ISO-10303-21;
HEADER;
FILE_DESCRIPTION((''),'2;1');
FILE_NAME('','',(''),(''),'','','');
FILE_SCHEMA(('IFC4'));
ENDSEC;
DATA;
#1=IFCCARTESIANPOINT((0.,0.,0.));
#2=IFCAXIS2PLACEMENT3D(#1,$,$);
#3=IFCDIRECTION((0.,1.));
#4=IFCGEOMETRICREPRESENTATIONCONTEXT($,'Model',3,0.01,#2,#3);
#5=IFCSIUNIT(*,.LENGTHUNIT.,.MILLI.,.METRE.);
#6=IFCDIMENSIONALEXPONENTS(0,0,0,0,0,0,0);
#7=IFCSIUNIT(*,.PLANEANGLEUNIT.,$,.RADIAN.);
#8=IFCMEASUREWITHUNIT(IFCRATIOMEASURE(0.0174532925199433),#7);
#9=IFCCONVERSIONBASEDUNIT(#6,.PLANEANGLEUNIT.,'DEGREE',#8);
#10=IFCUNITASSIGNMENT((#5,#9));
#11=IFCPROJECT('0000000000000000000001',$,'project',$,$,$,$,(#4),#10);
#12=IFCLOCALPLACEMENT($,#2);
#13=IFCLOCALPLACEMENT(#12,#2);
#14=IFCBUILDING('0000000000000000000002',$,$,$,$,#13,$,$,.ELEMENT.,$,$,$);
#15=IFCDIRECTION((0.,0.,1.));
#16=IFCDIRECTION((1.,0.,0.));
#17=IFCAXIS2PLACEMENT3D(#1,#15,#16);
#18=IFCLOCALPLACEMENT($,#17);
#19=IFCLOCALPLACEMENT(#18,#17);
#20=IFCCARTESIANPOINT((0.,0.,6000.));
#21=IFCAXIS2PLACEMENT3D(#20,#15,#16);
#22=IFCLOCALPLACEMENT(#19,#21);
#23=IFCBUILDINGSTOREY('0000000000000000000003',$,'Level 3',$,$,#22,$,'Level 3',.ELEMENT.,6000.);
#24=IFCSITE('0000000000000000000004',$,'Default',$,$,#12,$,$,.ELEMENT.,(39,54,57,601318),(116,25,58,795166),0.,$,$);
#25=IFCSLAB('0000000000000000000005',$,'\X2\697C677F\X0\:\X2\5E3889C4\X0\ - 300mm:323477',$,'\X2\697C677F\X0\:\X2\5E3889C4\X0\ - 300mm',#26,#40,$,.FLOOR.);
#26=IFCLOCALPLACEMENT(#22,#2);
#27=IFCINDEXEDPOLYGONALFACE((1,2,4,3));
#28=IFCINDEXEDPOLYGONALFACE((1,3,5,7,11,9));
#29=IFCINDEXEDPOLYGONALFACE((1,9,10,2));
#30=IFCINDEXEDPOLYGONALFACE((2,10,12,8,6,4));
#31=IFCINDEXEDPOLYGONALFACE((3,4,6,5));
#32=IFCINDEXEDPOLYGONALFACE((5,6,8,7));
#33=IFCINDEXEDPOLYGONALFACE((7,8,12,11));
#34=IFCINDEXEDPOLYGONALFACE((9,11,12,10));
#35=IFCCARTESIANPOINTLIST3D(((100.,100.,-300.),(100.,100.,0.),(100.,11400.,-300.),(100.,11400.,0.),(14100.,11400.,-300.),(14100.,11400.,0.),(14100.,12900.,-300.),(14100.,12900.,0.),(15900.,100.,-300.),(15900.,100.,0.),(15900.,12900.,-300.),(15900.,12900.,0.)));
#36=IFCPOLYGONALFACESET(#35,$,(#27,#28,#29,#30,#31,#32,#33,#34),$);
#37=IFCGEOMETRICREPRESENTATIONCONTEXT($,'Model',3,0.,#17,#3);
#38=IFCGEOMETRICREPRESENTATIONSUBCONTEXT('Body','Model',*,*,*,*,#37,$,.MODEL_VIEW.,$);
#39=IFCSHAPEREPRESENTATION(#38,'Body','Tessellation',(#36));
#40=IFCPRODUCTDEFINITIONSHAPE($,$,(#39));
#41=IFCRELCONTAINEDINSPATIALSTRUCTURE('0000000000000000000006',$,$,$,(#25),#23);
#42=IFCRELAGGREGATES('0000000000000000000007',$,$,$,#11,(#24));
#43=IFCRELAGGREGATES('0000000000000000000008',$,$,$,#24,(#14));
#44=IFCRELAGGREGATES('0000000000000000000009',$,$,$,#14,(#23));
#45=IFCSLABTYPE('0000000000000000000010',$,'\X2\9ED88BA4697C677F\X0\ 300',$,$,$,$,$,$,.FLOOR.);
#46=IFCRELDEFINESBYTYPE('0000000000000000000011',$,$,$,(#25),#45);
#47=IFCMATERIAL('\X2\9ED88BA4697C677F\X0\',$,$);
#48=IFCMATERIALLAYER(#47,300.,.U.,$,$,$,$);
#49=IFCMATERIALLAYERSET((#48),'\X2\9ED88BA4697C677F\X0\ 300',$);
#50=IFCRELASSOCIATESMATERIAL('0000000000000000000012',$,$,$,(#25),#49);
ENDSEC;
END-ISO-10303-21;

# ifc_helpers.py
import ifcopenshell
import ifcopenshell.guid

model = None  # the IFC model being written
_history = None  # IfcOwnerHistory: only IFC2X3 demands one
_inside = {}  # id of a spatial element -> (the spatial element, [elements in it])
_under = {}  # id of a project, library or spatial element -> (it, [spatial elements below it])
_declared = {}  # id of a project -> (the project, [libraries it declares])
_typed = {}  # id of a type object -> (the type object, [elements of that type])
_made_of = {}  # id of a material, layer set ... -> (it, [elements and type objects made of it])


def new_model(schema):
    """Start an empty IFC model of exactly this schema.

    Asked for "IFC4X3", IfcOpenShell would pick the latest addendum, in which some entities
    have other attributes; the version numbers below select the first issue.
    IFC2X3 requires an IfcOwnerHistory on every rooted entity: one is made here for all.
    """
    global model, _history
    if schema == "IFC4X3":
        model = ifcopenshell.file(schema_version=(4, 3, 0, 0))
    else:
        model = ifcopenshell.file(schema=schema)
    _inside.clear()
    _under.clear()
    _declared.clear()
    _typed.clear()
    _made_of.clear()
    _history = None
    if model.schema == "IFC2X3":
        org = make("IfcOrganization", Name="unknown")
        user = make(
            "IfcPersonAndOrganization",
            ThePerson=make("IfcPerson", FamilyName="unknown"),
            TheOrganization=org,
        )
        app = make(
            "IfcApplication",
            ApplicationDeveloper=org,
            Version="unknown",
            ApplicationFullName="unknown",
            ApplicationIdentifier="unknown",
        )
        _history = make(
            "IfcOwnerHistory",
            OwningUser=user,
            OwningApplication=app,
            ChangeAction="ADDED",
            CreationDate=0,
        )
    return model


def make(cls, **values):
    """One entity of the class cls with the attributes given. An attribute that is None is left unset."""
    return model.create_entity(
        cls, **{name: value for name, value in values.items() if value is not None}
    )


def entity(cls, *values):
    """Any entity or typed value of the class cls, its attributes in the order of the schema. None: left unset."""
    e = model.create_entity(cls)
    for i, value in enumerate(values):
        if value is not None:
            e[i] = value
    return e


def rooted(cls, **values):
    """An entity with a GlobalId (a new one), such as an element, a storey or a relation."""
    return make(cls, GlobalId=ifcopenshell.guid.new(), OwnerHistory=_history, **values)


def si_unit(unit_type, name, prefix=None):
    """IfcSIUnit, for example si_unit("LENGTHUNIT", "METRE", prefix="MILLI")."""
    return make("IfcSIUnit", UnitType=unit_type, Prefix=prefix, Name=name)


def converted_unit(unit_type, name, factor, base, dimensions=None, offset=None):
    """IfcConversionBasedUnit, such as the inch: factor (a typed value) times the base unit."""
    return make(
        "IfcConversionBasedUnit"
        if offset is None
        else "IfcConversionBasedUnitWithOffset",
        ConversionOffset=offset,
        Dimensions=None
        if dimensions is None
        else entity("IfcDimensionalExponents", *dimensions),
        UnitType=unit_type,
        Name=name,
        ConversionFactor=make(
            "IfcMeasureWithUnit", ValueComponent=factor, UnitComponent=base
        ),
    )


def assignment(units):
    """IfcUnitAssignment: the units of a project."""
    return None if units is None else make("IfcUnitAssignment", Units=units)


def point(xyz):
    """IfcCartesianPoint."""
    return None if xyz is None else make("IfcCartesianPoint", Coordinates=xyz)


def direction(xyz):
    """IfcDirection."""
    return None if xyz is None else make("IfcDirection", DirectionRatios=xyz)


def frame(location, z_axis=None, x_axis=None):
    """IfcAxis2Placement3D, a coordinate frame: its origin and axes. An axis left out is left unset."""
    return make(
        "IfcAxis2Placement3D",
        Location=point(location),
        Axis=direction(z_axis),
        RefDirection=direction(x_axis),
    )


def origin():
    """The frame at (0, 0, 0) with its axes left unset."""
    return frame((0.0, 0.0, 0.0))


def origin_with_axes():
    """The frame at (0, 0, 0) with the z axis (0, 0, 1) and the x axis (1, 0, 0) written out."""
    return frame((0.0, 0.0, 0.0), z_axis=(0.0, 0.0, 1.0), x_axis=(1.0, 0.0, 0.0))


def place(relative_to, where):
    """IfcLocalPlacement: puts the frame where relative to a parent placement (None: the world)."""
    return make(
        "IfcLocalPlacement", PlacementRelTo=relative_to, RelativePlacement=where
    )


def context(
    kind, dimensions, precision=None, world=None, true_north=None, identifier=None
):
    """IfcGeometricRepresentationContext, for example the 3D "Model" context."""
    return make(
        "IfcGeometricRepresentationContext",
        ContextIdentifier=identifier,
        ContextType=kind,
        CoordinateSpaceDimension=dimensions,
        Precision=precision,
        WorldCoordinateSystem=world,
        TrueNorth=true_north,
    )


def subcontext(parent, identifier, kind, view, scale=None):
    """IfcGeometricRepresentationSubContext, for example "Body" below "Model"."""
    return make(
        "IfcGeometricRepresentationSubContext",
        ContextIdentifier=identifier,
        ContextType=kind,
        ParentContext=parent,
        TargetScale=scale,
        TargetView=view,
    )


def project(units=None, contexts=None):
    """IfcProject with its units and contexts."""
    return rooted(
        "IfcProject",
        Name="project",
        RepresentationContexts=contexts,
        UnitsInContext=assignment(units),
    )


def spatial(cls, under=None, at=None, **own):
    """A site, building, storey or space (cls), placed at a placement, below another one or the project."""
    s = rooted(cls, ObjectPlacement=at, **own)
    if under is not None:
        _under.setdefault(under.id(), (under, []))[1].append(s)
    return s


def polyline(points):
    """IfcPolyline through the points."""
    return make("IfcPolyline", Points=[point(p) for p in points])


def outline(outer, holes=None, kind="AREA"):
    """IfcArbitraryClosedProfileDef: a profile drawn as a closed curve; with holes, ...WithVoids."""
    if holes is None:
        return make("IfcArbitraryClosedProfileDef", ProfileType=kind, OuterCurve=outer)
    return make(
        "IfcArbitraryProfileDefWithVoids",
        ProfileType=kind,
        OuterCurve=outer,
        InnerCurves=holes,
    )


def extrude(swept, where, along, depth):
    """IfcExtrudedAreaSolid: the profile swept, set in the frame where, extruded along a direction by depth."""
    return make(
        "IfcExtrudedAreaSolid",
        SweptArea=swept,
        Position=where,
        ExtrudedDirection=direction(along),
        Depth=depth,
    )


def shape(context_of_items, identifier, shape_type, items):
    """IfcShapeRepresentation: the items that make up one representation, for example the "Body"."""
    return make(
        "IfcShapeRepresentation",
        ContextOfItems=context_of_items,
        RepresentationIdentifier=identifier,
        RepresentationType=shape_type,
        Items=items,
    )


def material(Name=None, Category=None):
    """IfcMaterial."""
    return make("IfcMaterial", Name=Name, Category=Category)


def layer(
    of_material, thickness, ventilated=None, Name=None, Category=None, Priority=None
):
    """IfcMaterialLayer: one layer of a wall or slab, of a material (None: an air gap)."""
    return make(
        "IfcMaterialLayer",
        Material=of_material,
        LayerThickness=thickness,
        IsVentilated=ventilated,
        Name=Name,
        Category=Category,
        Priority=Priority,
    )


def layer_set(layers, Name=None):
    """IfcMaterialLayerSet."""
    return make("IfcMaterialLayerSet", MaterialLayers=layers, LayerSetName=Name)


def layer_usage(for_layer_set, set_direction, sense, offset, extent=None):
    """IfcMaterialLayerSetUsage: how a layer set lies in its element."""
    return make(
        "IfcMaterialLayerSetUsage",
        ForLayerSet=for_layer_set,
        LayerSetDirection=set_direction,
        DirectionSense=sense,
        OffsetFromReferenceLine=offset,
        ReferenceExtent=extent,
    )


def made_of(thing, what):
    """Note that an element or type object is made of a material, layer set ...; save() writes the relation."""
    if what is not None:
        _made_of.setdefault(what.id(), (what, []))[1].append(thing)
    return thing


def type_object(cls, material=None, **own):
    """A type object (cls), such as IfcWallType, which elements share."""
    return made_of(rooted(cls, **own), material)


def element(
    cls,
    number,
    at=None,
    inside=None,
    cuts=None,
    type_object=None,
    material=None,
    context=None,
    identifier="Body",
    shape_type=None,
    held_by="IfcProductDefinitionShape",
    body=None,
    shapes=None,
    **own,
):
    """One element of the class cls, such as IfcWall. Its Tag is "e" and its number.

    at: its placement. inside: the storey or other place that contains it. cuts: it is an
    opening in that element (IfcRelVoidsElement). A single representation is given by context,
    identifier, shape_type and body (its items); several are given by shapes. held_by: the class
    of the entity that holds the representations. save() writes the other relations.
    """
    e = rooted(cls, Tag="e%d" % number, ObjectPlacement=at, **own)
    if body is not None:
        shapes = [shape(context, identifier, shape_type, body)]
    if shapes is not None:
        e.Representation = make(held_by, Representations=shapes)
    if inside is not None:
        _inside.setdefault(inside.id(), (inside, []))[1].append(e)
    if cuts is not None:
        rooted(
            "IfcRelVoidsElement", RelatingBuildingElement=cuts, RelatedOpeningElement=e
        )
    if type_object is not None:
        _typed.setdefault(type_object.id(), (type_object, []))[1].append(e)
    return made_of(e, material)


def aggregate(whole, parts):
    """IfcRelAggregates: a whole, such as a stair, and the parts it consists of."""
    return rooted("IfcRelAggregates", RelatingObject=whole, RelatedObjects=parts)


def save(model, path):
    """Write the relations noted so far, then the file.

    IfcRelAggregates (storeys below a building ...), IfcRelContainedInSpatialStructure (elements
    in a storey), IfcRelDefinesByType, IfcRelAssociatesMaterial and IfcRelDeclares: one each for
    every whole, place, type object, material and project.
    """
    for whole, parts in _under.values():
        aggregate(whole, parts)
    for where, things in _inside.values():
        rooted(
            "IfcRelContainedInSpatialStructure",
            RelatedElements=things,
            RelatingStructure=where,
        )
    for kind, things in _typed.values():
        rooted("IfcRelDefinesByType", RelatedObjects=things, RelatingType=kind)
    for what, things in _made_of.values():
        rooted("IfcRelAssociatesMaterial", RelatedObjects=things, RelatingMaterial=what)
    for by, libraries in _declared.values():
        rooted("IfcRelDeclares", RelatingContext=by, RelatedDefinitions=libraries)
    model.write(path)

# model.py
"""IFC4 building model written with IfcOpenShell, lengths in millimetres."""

from ifc_helpers import new_model, entity, si_unit, converted_unit, direction, frame, origin, origin_with_axes, place, context, subcontext, project, spatial, polyline, outline, extrude, material, layer, layer_set, layer_usage, type_object, element, save


model = new_model("IFC4")

# Units and contexts
model_context_1 = context("Model", 3, precision=0.01, world=origin(), true_north=direction((0.0, 1.0)))
model_context_2 = context("Model", 3, precision=0.0, world=origin_with_axes(), true_north=direction((0.0, 1.0)))
body_context = subcontext(model_context_2, "Body", "Model", "MODEL_VIEW")
ifc_project = project(units=[si_unit("LENGTHUNIT", "METRE", prefix="MILLI"), converted_unit("PLANEANGLEUNIT", "DEGREE", entity("IfcRatioMeasure", 0.0174532925199433), si_unit("PLANEANGLEUNIT", "RADIAN"), dimensions=[0, 0, 0, 0, 0, 0, 0])], contexts=[model_context_1])

# Site, building, storey
site_placement = place(None, origin())
site = spatial("IfcSite", under=ifc_project, at=site_placement, Name="Default", CompositionType="ELEMENT", RefLatitude=(39, 54, 57, 601318), RefLongitude=(116, 25, 58, 795166), RefElevation=0.0)
building_placement = place(site_placement, origin())
building = spatial("IfcBuilding", under=site, at=building_placement, CompositionType="ELEMENT")
placement_1 = place(None, origin_with_axes())
placement_2 = place(placement_1, origin_with_axes())
storey_placement = place(placement_2, frame((0.0, 0.0, 6000.0), z_axis=(0.0, 0.0, 1.0), x_axis=(1.0, 0.0, 0.0)))
storey = spatial("IfcBuildingStorey", under=building, at=storey_placement, Name="Level 3", LongName="Level 3", CompositionType="ELEMENT", Elevation=6000.0)

# Slab
ifc_material = material(Name="默认楼板")
ifc_layer = layer(ifc_material, 300.0, ventilated="UNKNOWN")
ifc_layer_set = layer_set([ifc_layer], Name="默认楼板 300")
ifc_layer_usage = layer_usage(ifc_layer_set, "AXIS3", "NEGATIVE", 300.0)
slab_type = type_object("IfcSlabType", Name="默认楼板 300", PredefinedType="FLOOR")
slab_placement = place(storey_placement, frame((100.0, 100.0, 0.0), z_axis=(0.0, 0.0, 1.0), x_axis=(1.0, 0.0, 0.0)))
element("IfcSlab", 1, at=slab_placement, inside=storey, type_object=slab_type, material=ifc_layer_usage, Name="楼板:常规 - 300mm:323477", ObjectType="楼板:常规 - 300mm", PredefinedType="FLOOR", context=body_context, shape_type="SweptSolid", body=[
    extrude(outline(polyline([(0.0, 0.0), (15800.0, 0.0), (15800.0, 12800.0), (14000.0, 12800.0), (14000.0, 11300.0), (0.0, 11300.0), (0.0, 0.0)])), frame((0.0, 0.0, -300.0), z_axis=(0.0, 0.0, 1.0), x_axis=(1.0, 0.0, 0.0)), (0.0, 0.0, 1.0), 300.0),
])

save(model, "model.ifc")
